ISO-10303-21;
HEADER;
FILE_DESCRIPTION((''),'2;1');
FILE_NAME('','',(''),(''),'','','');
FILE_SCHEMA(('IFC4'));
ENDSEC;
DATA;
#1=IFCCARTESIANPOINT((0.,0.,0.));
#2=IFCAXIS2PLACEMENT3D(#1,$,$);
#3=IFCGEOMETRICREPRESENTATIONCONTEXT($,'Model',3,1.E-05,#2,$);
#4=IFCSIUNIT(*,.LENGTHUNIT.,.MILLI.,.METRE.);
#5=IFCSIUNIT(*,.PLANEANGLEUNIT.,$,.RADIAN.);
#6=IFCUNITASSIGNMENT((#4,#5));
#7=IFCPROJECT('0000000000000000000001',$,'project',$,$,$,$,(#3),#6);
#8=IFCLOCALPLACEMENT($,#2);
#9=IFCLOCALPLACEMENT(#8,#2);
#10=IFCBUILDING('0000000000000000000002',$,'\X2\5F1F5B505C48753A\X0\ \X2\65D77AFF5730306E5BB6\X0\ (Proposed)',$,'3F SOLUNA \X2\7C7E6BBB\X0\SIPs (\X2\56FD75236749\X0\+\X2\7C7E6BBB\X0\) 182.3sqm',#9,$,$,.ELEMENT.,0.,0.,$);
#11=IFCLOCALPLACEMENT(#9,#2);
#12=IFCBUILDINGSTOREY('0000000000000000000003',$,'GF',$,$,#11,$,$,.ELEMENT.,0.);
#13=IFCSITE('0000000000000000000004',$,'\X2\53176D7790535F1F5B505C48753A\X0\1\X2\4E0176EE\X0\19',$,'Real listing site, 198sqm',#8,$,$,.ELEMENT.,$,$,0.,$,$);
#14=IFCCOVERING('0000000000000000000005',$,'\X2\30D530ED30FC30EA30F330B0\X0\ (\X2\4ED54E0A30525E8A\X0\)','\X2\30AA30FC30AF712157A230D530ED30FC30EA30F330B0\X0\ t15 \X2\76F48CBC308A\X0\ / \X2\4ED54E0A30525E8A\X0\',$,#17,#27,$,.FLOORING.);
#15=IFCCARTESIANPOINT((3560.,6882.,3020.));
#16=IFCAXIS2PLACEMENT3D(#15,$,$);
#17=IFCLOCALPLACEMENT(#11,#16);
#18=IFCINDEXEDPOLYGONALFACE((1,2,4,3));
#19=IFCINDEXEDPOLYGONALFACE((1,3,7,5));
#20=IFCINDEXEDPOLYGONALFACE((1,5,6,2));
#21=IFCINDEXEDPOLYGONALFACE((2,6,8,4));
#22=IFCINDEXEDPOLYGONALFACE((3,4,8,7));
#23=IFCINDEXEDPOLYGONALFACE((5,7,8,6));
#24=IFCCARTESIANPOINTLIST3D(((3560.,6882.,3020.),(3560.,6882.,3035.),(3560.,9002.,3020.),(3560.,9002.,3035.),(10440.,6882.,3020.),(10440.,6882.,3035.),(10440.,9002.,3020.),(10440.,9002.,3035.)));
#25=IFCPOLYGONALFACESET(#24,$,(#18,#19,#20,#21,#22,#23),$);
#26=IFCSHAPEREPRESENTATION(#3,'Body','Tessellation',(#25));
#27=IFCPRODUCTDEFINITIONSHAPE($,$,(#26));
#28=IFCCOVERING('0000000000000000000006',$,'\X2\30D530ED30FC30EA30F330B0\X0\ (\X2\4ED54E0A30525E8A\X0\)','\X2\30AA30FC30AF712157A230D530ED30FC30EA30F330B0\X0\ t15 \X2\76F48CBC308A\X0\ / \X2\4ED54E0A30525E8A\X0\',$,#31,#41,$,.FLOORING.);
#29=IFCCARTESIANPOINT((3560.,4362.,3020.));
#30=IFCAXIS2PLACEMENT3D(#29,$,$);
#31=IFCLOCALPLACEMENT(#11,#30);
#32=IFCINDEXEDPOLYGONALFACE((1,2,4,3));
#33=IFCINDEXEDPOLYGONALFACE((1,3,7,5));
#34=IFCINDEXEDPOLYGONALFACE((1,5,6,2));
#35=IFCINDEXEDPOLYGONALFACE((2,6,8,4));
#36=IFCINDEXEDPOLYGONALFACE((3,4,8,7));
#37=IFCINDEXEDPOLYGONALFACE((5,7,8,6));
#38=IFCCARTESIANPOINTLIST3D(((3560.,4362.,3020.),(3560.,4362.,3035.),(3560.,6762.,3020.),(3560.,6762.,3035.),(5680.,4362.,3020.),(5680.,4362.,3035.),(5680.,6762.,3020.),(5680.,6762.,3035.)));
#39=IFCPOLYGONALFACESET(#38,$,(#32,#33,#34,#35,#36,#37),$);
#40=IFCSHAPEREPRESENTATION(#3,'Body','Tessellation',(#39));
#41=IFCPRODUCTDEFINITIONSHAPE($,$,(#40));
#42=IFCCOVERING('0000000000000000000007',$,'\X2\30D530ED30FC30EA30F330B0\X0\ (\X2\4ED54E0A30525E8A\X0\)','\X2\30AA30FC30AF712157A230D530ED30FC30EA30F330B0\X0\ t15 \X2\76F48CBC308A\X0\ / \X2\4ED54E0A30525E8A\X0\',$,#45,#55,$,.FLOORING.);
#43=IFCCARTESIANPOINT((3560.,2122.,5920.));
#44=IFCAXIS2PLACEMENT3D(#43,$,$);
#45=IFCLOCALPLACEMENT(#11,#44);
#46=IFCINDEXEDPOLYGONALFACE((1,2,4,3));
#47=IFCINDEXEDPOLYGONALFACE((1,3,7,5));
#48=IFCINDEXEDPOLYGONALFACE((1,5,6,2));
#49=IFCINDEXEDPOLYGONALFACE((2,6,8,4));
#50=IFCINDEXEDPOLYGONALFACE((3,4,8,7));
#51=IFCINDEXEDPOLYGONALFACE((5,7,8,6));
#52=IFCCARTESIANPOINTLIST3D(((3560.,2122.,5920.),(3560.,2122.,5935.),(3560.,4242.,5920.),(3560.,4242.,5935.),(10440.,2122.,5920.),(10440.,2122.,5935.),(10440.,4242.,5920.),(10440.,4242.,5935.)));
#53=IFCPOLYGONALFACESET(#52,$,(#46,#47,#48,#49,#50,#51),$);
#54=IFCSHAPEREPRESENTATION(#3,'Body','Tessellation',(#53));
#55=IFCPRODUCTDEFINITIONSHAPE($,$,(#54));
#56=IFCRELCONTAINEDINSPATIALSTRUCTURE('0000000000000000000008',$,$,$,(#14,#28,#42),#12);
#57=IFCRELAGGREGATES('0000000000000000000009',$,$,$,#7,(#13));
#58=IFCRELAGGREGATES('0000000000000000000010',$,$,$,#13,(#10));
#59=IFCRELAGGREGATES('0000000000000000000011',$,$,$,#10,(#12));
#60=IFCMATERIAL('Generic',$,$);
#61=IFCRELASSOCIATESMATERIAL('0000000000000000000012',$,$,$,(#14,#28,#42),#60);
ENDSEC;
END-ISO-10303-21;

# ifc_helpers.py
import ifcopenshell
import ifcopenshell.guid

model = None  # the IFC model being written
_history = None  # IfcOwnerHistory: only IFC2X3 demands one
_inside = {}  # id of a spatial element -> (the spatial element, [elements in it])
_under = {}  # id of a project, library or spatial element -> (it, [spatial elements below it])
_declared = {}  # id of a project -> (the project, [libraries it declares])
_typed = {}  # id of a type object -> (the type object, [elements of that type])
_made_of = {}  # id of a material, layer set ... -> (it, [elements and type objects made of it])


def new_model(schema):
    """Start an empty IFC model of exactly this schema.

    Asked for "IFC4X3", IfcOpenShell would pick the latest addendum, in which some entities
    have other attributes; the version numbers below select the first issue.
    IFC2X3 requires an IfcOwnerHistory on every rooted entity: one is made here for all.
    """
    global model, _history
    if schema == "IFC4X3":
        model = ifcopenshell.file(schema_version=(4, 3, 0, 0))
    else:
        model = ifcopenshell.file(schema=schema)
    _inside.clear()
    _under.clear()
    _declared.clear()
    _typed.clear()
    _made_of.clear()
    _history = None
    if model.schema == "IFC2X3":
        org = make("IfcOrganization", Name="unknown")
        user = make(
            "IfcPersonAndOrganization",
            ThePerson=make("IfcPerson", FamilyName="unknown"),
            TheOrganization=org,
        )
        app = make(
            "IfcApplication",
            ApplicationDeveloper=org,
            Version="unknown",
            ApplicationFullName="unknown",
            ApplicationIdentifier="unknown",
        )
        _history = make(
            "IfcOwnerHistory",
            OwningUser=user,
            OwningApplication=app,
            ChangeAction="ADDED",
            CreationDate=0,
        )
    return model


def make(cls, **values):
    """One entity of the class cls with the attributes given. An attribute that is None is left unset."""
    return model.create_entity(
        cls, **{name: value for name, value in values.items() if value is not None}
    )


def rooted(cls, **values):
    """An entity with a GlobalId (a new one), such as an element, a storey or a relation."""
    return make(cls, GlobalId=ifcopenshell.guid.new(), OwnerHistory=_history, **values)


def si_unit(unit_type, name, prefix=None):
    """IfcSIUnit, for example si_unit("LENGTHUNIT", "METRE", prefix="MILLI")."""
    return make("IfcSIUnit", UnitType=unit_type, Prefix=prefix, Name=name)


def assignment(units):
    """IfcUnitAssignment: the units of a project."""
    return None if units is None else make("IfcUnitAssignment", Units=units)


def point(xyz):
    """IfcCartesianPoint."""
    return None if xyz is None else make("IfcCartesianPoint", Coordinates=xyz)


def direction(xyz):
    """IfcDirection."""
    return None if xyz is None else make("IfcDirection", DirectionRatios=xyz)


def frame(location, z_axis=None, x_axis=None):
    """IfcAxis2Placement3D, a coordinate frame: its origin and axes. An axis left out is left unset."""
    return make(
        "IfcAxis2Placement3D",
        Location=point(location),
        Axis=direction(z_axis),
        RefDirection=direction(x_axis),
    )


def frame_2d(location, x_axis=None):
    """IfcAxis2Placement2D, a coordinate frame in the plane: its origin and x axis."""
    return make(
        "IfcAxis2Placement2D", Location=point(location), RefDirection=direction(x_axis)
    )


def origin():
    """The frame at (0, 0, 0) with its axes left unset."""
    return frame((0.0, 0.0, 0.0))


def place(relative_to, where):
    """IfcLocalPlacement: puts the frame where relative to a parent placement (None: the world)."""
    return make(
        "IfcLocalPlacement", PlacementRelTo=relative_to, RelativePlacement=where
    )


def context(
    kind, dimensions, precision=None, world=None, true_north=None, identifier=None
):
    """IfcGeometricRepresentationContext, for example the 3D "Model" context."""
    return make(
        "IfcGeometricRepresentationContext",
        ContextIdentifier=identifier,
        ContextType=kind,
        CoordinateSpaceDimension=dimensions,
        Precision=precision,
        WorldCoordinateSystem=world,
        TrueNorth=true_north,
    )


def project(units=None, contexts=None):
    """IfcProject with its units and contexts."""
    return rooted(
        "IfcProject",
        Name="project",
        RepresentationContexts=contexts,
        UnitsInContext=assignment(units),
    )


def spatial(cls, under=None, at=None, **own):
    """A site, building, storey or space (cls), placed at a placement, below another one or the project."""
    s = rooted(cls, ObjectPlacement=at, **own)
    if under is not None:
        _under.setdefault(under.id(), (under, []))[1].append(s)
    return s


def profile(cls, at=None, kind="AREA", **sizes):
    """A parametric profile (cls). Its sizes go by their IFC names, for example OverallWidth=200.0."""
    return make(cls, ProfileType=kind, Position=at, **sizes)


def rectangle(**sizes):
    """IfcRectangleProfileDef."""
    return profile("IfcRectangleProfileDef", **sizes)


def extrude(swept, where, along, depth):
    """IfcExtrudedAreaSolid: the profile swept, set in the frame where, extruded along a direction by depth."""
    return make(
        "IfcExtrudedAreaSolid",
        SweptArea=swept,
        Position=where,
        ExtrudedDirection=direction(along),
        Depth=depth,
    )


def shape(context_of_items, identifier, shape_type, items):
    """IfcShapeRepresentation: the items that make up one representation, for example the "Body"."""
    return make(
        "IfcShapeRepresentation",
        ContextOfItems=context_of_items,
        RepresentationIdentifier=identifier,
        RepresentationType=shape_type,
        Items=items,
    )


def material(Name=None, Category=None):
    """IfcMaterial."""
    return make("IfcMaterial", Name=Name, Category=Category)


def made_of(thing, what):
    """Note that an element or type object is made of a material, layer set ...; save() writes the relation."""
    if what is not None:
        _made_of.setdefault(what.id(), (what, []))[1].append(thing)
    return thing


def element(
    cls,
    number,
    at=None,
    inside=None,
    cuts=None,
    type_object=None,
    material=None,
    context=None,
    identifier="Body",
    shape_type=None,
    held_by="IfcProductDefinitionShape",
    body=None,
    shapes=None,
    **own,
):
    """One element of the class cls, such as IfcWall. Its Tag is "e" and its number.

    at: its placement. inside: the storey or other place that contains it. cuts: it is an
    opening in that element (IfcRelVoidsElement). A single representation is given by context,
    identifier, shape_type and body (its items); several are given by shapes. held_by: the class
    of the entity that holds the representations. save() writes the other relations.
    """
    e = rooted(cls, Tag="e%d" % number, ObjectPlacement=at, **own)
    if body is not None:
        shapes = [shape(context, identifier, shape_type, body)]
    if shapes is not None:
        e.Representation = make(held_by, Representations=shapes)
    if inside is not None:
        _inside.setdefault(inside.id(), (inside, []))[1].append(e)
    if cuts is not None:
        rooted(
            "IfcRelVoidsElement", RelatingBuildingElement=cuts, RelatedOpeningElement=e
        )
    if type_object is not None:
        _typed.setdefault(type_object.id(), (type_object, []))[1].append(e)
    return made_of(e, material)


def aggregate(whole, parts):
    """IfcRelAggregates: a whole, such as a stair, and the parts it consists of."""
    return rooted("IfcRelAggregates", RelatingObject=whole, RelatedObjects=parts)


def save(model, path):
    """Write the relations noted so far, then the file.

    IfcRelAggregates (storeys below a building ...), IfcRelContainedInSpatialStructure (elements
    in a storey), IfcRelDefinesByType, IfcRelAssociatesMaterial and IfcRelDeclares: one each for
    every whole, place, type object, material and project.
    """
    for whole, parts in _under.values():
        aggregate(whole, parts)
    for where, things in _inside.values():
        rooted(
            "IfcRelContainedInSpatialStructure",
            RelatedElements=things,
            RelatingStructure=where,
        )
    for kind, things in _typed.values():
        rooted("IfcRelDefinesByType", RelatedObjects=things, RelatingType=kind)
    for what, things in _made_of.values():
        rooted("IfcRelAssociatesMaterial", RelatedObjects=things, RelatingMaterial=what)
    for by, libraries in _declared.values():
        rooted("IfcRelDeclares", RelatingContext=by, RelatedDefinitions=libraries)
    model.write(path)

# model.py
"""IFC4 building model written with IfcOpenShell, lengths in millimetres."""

from ifc_helpers import new_model, si_unit, frame, frame_2d, origin, place, context, project, spatial, rectangle, extrude, material, element, save


model = new_model("IFC4")

# Units and contexts
model_context = context("Model", 3, precision=1e-05, world=origin())
ifc_project = project(units=[si_unit("LENGTHUNIT", "METRE", prefix="MILLI"), si_unit("PLANEANGLEUNIT", "RADIAN")], contexts=[model_context])

# Site, building, storey
site_placement = place(None, origin())
site = spatial("IfcSite", under=ifc_project, at=site_placement, Name="北海道弟子屈町1丁目19", ObjectType="Real listing site, 198sqm", CompositionType="ELEMENT", RefElevation=0.0)
building_placement = place(site_placement, origin())
building = spatial("IfcBuilding", under=site, at=building_placement, Name="弟子屈町 旗竿地の家 (Proposed)", ObjectType="3F SOLUNA 籾殻SIPs (国産杉+籾殻) 182.3sqm", CompositionType="ELEMENT", ElevationOfRefHeight=0.0, ElevationOfTerrain=0.0)
storey_placement = place(building_placement, origin())
storey = spatial("IfcBuildingStorey", under=building, at=storey_placement, Name="GF", CompositionType="ELEMENT", Elevation=0.0)

# Shared definitions
ifc_material_1 = material(Name="Generic")

# Coverings
covering_1_placement = place(storey_placement, frame((3560.0, 6882.0, 3020.0)))
element("IfcCovering", 1, at=covering_1_placement, inside=storey, material=ifc_material_1, Name="フローリング (仕上げ床)", Description="オーク無垢フローリング t15 直貼り / 仕上げ床", PredefinedType="FLOORING", context=model_context, shape_type="SweptSolid", body=[
    extrude(rectangle(XDim=6880.0, YDim=2120.0, at=frame_2d((3440.0, 1060.0))), frame((3560.0, 6882.0, 3020.0)), (0.0, 0.0, 1.0), 15.0),
])
covering_2_placement = place(storey_placement, frame((3560.0, 4362.0, 3020.0)))
element("IfcCovering", 2, at=covering_2_placement, inside=storey, material=ifc_material_1, Name="フローリング (仕上げ床)", Description="オーク無垢フローリング t15 直貼り / 仕上げ床", PredefinedType="FLOORING", context=model_context, shape_type="SweptSolid", body=[
    extrude(rectangle(XDim=2120.0, YDim=2400.0, at=frame_2d((1060.0, 1200.0))), frame((3560.0, 4362.0, 3020.0)), (0.0, 0.0, 1.0), 15.0),
])
covering_3_placement = place(storey_placement, frame((3560.0, 2122.0, 5920.0)))
element("IfcCovering", 3, at=covering_3_placement, inside=storey, material=ifc_material_1, Name="フローリング (仕上げ床)", Description="オーク無垢フローリング t15 直貼り / 仕上げ床", PredefinedType="FLOORING", context=model_context, shape_type="SweptSolid", body=[
    extrude(rectangle(XDim=6880.0, YDim=2120.0, at=frame_2d((3440.0, 1060.0))), frame((3560.0, 2122.0, 5920.0)), (0.0, 0.0, 1.0), 15.0),
])

save(model, "model.ifc")
